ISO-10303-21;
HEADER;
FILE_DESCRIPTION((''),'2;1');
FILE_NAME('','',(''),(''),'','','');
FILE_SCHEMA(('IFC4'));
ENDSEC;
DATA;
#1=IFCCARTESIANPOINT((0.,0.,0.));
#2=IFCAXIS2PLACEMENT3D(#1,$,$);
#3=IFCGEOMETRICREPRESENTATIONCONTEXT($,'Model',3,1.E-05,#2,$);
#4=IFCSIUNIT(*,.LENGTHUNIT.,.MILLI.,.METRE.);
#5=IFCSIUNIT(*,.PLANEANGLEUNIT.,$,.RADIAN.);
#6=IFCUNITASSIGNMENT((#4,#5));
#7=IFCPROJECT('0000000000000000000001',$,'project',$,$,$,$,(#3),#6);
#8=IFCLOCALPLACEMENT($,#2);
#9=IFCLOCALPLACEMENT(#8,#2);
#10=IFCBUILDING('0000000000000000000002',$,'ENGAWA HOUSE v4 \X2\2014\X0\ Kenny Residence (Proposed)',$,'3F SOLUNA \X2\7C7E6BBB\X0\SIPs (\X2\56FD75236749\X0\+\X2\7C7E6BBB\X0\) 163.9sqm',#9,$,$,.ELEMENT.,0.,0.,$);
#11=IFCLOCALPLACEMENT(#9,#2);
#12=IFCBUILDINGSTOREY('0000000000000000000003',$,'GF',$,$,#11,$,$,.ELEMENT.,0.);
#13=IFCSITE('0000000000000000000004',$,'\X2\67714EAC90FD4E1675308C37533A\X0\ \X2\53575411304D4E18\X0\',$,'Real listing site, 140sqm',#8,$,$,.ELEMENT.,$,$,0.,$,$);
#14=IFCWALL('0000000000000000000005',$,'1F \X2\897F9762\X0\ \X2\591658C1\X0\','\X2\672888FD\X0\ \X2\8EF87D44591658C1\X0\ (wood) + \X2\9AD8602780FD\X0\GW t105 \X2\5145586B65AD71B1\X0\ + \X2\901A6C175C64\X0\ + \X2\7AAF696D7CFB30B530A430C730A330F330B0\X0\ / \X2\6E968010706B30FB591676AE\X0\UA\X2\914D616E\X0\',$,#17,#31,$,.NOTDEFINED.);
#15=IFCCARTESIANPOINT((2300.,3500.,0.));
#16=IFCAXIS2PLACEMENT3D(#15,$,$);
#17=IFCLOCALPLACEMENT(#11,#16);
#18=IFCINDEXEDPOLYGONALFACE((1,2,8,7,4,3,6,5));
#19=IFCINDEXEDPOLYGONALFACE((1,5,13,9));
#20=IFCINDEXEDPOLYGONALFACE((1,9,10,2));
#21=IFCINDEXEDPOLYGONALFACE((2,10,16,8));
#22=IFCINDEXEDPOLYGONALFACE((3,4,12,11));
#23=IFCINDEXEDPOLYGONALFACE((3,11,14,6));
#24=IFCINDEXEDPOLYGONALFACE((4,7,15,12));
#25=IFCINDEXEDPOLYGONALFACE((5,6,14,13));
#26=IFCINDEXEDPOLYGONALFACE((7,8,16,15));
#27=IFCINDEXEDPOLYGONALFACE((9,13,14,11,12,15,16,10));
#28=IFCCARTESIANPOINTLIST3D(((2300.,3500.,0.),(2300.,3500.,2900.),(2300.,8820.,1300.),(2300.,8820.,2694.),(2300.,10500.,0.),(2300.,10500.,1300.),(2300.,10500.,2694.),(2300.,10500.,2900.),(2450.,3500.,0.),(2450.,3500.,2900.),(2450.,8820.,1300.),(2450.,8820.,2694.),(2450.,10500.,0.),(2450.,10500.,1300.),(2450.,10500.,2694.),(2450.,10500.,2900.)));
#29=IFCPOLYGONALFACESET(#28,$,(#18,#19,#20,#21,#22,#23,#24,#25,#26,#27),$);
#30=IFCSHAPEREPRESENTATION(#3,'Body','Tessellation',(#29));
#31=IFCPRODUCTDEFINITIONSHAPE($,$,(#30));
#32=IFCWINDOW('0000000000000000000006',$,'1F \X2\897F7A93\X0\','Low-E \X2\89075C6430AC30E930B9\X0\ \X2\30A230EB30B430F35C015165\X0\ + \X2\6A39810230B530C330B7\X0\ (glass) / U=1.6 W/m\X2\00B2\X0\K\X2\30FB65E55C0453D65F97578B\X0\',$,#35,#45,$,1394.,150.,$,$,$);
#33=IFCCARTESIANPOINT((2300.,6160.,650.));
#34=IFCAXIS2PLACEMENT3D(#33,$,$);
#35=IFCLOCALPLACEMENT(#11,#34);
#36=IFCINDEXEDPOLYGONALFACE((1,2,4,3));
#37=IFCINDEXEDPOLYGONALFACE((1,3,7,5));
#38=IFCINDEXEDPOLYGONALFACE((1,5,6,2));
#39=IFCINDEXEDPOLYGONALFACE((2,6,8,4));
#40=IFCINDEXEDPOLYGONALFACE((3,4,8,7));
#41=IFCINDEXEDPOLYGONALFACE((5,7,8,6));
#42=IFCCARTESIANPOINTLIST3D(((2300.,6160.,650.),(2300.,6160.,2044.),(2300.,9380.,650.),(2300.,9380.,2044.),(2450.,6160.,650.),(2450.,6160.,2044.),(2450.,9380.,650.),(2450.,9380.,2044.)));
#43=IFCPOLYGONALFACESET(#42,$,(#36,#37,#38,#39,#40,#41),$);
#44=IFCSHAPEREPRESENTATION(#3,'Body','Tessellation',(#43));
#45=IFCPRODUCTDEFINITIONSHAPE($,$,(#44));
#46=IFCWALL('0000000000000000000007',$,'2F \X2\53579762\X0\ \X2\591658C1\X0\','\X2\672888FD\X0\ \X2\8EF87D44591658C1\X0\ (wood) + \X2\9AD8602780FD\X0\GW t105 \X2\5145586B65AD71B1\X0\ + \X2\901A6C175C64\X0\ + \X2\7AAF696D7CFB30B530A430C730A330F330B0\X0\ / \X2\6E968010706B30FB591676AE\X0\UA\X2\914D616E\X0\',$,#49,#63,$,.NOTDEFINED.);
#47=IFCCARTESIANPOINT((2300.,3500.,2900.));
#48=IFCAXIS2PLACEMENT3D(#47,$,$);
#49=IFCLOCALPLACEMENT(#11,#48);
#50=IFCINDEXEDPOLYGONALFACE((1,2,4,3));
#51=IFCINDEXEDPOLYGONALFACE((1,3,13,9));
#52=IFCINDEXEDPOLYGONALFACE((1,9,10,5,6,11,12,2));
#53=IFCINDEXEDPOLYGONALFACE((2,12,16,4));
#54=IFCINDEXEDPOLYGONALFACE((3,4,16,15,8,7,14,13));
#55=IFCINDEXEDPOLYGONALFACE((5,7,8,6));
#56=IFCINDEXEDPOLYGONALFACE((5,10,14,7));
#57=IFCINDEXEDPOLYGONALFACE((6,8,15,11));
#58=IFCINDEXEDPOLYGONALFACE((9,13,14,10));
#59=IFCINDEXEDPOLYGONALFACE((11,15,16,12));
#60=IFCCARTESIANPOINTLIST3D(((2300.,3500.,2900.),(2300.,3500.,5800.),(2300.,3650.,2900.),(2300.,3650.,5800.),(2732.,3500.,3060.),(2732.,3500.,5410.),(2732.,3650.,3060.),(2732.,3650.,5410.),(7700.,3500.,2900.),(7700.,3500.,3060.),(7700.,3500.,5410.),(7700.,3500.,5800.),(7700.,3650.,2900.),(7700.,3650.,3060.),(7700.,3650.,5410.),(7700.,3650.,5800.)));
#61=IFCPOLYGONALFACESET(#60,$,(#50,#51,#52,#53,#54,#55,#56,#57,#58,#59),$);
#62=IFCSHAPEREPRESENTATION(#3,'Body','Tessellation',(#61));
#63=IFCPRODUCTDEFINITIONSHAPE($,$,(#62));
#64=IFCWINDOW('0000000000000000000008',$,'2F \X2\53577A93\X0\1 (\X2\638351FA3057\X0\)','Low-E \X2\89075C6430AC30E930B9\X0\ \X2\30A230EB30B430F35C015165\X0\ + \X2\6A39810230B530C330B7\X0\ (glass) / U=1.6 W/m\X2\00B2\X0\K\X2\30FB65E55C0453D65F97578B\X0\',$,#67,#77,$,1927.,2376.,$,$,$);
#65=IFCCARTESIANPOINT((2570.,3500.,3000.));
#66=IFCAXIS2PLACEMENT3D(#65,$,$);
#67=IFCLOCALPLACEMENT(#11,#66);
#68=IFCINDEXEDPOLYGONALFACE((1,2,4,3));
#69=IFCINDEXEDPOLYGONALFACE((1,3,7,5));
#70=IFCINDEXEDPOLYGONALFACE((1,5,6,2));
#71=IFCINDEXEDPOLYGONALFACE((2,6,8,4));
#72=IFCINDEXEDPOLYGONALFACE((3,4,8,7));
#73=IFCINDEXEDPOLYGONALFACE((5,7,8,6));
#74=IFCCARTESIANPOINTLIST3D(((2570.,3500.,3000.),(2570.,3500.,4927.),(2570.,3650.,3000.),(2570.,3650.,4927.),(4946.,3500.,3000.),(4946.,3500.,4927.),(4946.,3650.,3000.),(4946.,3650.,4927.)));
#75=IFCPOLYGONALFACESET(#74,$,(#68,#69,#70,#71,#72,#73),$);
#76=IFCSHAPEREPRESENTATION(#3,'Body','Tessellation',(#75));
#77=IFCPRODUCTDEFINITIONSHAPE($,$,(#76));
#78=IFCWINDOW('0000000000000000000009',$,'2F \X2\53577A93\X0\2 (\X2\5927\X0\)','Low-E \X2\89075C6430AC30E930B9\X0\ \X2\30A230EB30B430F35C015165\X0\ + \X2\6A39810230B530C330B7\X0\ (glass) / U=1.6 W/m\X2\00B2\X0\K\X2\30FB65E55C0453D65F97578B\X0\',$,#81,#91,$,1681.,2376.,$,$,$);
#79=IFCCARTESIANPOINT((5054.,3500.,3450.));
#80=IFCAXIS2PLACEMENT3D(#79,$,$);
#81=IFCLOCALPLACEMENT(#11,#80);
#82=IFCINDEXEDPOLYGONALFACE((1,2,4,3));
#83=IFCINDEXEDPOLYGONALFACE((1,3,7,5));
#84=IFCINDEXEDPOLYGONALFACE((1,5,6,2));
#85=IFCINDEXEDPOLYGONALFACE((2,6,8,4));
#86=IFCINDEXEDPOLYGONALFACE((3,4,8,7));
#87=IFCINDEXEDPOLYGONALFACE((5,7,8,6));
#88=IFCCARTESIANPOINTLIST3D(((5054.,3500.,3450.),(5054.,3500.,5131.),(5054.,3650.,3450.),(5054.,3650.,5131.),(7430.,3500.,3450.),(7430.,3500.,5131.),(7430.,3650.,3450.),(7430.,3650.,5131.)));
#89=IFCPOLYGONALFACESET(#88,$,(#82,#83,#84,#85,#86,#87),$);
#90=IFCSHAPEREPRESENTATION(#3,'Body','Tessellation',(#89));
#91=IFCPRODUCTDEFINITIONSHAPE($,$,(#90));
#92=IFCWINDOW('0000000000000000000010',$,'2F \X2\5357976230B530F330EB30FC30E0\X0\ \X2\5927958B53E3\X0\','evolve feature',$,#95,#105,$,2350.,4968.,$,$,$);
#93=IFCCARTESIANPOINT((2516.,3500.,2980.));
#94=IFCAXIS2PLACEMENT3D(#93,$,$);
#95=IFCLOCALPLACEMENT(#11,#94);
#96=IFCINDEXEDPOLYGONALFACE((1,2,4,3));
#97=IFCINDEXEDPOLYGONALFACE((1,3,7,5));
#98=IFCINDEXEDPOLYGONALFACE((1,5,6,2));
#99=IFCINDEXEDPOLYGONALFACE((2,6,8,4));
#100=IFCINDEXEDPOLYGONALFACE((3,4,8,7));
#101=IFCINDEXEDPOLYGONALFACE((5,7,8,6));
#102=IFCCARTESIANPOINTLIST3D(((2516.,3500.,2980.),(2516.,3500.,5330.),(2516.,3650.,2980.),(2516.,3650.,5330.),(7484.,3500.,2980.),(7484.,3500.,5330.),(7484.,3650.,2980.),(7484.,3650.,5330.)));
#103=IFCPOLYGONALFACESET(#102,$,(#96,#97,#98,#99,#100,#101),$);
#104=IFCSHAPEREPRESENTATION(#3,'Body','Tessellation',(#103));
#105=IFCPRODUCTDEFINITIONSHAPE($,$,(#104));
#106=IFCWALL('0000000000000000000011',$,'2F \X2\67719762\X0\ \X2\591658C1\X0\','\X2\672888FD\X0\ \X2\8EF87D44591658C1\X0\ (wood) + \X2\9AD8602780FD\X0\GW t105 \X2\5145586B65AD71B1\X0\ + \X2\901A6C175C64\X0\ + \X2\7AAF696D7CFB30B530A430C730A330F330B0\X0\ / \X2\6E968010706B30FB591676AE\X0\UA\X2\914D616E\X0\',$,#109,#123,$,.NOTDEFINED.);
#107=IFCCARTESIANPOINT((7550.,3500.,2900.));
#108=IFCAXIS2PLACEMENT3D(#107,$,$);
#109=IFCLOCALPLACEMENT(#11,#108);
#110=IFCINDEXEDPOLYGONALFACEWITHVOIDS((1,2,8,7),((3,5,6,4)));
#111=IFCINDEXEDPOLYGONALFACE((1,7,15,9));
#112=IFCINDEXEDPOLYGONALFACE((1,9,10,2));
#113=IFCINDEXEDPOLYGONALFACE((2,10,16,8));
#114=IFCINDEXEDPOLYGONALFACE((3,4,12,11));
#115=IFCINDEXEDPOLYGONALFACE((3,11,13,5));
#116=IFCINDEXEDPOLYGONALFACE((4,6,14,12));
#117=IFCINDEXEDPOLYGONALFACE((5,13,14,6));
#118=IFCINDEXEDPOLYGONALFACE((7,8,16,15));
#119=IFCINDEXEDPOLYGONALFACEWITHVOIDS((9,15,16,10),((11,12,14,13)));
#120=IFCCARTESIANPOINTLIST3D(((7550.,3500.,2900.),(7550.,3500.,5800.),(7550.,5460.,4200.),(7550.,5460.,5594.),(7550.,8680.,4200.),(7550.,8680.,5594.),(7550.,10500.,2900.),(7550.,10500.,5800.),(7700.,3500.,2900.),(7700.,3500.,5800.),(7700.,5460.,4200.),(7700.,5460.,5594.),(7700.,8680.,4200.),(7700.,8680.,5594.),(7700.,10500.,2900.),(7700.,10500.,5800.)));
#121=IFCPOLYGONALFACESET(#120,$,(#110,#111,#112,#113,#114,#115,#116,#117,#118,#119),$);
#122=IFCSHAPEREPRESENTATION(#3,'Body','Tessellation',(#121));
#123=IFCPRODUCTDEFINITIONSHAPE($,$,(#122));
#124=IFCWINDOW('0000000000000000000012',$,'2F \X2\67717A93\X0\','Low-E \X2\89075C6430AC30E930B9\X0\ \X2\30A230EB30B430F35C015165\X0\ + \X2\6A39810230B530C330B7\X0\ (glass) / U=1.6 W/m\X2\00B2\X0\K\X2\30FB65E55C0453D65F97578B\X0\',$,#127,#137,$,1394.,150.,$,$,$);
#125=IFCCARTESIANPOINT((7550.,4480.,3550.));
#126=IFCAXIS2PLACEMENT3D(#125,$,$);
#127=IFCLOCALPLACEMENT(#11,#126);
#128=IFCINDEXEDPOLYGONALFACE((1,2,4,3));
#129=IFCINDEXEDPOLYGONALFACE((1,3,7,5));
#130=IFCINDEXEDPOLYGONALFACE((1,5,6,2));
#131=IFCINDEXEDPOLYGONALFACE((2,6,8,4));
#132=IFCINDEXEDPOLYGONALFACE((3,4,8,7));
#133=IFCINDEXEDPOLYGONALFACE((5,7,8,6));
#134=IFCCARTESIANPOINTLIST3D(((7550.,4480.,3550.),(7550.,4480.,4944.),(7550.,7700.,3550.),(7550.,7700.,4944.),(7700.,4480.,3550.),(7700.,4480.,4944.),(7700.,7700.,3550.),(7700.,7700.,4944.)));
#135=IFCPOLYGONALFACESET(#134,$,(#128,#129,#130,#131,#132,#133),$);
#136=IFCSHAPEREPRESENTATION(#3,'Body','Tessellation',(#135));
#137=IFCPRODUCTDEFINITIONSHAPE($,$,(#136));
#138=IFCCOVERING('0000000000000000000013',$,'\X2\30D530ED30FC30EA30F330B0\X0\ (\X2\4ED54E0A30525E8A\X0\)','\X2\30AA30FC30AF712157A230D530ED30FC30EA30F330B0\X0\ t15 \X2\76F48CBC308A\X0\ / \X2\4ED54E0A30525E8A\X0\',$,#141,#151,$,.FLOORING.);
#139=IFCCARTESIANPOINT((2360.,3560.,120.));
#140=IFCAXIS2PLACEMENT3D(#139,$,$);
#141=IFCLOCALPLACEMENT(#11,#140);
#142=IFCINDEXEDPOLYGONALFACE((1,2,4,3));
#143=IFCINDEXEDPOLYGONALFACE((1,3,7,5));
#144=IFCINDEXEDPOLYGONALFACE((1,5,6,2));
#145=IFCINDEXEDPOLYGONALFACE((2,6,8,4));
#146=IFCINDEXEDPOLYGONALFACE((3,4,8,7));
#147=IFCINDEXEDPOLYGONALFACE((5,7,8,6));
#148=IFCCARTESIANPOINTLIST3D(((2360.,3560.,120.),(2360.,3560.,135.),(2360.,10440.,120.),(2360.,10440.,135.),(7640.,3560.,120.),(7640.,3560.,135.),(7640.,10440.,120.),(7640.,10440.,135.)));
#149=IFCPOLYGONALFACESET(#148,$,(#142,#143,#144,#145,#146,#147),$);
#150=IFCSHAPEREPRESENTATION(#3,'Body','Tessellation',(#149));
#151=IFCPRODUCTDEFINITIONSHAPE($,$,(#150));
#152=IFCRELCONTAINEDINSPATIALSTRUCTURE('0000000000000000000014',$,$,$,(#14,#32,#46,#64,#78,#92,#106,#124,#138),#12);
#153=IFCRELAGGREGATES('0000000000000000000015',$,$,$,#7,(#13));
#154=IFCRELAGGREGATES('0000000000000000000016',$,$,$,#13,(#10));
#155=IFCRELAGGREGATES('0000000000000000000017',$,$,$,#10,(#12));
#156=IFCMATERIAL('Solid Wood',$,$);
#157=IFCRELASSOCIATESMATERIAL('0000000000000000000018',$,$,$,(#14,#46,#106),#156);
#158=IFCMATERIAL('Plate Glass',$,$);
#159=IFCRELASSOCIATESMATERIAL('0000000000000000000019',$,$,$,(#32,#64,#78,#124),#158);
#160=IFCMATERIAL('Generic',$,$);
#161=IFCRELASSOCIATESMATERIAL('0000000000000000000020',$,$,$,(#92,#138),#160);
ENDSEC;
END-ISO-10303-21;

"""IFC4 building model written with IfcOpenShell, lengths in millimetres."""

from ifc_helpers import new_model, si_unit, frame, frame_2d, origin, place, context, project, spatial, rectangle, extrude, material, element, fill, save


model = new_model("IFC4")

# Units and contexts
model_context = context("Model", 3, precision=1e-05, world=origin())
ifc_project = project(units=[si_unit("LENGTHUNIT", "METRE", prefix="MILLI"), si_unit("PLANEANGLEUNIT", "RADIAN")], contexts=[model_context])

# Site, building, storey
site_placement = place(None, origin())
site = spatial("IfcSite", under=ifc_project, at=site_placement, Name="東京都世田谷区 南向き丘", ObjectType="Real listing site, 140sqm", CompositionType="ELEMENT", RefElevation=0.0)
building_placement = place(site_placement, origin())
building = spatial("IfcBuilding", under=site, at=building_placement, Name="ENGAWA HOUSE v4 — Kenny Residence (Proposed)", ObjectType="3F SOLUNA 籾殻SIPs (国産杉+籾殻) 163.9sqm", CompositionType="ELEMENT", ElevationOfRefHeight=0.0, ElevationOfTerrain=0.0)
storey_placement = place(building_placement, origin())
storey = spatial("IfcBuildingStorey", under=building, at=storey_placement, Name="GF", CompositionType="ELEMENT", Elevation=0.0)

# Shared definitions
ifc_material_1 = material(Name="Solid Wood")
ifc_material_2 = material(Name="Generic")

# Shared definitions
ifc_material_3 = material(Name="Plate Glass")

# Wall, opening, window
wall_1_placement = place(storey_placement, frame((2300.0, 3500.0, 0.0)))
wall_1 = element("IfcWall", 1, at=wall_1_placement, inside=storey, material=ifc_material_1, Name="1F 西面 外壁", Description="木製 軸組外壁 (wood) + 高性能GW t105 充填断熱 + 通気層 + 窯業系サイディング / 準耐火・外皮UA配慮", PredefinedType="NOTDEFINED", context=model_context, shape_type="SweptSolid", body=[
    extrude(rectangle(XDim=150.0, YDim=7000.0, at=frame_2d((75.0, 3500.0))), frame((2300.0, 3500.0, 0.0)), (0.0, 0.0, 1.0), 2900.0),
])
opening_1_placement = place(storey_placement, frame((2300.0, 6160.0, 650.0)))
opening_1 = element("IfcOpeningElement", 2, at=opening_1_placement, cuts=wall_1, PredefinedType="NOTDEFINED", context=model_context, shape_type="SweptSolid", body=[
    extrude(rectangle(XDim=150.0, YDim=3220.0, at=frame_2d((75.0, 1610.0))), frame((2300.0, 6160.0, 650.0)), (0.0, 0.0, 1.0), 1394.0),
])
window_1_placement = place(storey_placement, frame((2300.0, 6160.0, 650.0)))
window_1 = element("IfcWindow", 3, at=window_1_placement, inside=storey, material=ifc_material_3, Name="1F 西窓", Description="Low-E 複層ガラス アルゴン封入 + 樹脂サッシ (glass) / U=1.6 W/m²K・日射取得型", OverallHeight=1394.0, OverallWidth=150.0, context=model_context, shape_type="SweptSolid", body=[
    extrude(rectangle(XDim=150.0, YDim=3220.0, at=frame_2d((75.0, 1610.0))), frame((2300.0, 6160.0, 650.0)), (0.0, 0.0, 1.0), 1394.0),
])
fill(opening_1, window_1)

# Wall, openings, windows
wall_2_placement = place(storey_placement, frame((2300.0, 3500.0, 2900.0)))
wall_2 = element("IfcWall", 4, at=wall_2_placement, inside=storey, material=ifc_material_1, Name="2F 南面 外壁", Description="木製 軸組外壁 (wood) + 高性能GW t105 充填断熱 + 通気層 + 窯業系サイディング / 準耐火・外皮UA配慮", PredefinedType="NOTDEFINED", context=model_context, shape_type="SweptSolid", body=[
    extrude(rectangle(XDim=5400.0, YDim=150.0, at=frame_2d((2700.0, 75.0))), frame((2300.0, 3500.0, 2900.0)), (0.0, 0.0, 1.0), 2900.0),
])
opening_2_placement = place(storey_placement, frame((2570.0, 3500.0, 3000.0)))
opening_2 = element("IfcOpeningElement", 5, at=opening_2_placement, cuts=wall_2, PredefinedType="NOTDEFINED", context=model_context, shape_type="SweptSolid", body=[
    extrude(rectangle(XDim=2376.0, YDim=150.0, at=frame_2d((1188.0, 75.0))), frame((2570.0, 3500.0, 3000.0)), (0.0, 0.0, 1.0), 1927.0),
])
opening_3_placement = place(storey_placement, frame((5054.0, 3500.0, 3450.0)))
opening_3 = element("IfcOpeningElement", 6, at=opening_3_placement, cuts=wall_2, PredefinedType="NOTDEFINED", context=model_context, shape_type="SweptSolid", body=[
    extrude(rectangle(XDim=2376.0, YDim=150.0, at=frame_2d((1188.0, 75.0))), frame((5054.0, 3500.0, 3450.0)), (0.0, 0.0, 1.0), 1681.0),
])
opening_4_placement = place(storey_placement, frame((2516.0, 3500.0, 2980.0)))
opening_4 = element("IfcOpeningElement", 7, at=opening_4_placement, cuts=wall_2, PredefinedType="NOTDEFINED", context=model_context, shape_type="SweptSolid", body=[
    extrude(rectangle(XDim=4968.0, YDim=150.0, at=frame_2d((2484.0, 75.0))), frame((2516.0, 3500.0, 2980.0)), (0.0, 0.0, 1.0), 2350.0),
])
window_2_placement = place(storey_placement, frame((2570.0, 3500.0, 3000.0)))
window_2 = element("IfcWindow", 8, at=window_2_placement, inside=storey, material=ifc_material_3, Name="2F 南窓1 (掃出し)", Description="Low-E 複層ガラス アルゴン封入 + 樹脂サッシ (glass) / U=1.6 W/m²K・日射取得型", OverallHeight=1927.0, OverallWidth=2376.0, context=model_context, shape_type="SweptSolid", body=[
    extrude(rectangle(XDim=2376.0, YDim=150.0, at=frame_2d((1188.0, 75.0))), frame((2570.0, 3500.0, 3000.0)), (0.0, 0.0, 1.0), 1927.0),
])
fill(opening_2, window_2)
window_3_placement = place(storey_placement, frame((5054.0, 3500.0, 3450.0)))
window_3 = element("IfcWindow", 9, at=window_3_placement, inside=storey, material=ifc_material_3, Name="2F 南窓2 (大)", Description="Low-E 複層ガラス アルゴン封入 + 樹脂サッシ (glass) / U=1.6 W/m²K・日射取得型", OverallHeight=1681.0, OverallWidth=2376.0, context=model_context, shape_type="SweptSolid", body=[
    extrude(rectangle(XDim=2376.0, YDim=150.0, at=frame_2d((1188.0, 75.0))), frame((5054.0, 3500.0, 3450.0)), (0.0, 0.0, 1.0), 1681.0),
])
fill(opening_3, window_3)
window_4_placement = place(storey_placement, frame((2516.0, 3500.0, 2980.0)))
window_4 = element("IfcWindow", 10, at=window_4_placement, inside=storey, material=ifc_material_2, Name="2F 南面サンルーム 大開口", Description="evolve feature", OverallHeight=2350.0, OverallWidth=4968.0, context=model_context, shape_type="SweptSolid", body=[
    extrude(rectangle(XDim=4968.0, YDim=150.0, at=frame_2d((2484.0, 75.0))), frame((2516.0, 3500.0, 2980.0)), (0.0, 0.0, 1.0), 2350.0),
])
fill(opening_4, window_4)

# Wall, opening, window
wall_3_placement = place(storey_placement, frame((7550.0, 3500.0, 2900.0)))
wall_3 = element("IfcWall", 11, at=wall_3_placement, inside=storey, material=ifc_material_1, Name="2F 東面 外壁", Description="木製 軸組外壁 (wood) + 高性能GW t105 充填断熱 + 通気層 + 窯業系サイディング / 準耐火・外皮UA配慮", PredefinedType="NOTDEFINED", context=model_context, shape_type="SweptSolid", body=[
    extrude(rectangle(XDim=150.0, YDim=7000.0, at=frame_2d((75.0, 3500.0))), frame((7550.0, 3500.0, 2900.0)), (0.0, 0.0, 1.0), 2900.0),
])
opening_5_placement = place(storey_placement, frame((7550.0, 4480.0, 3550.0)))
opening_5 = element("IfcOpeningElement", 12, at=opening_5_placement, cuts=wall_3, PredefinedType="NOTDEFINED", context=model_context, shape_type="SweptSolid", body=[
    extrude(rectangle(XDim=150.0, YDim=3220.0, at=frame_2d((75.0, 1610.0))), frame((7550.0, 4480.0, 3550.0)), (0.0, 0.0, 1.0), 1394.0),
])
window_5_placement = place(storey_placement, frame((7550.0, 4480.0, 3550.0)))
window_5 = element("IfcWindow", 13, at=window_5_placement, inside=storey, material=ifc_material_3, Name="2F 東窓", Description="Low-E 複層ガラス アルゴン封入 + 樹脂サッシ (glass) / U=1.6 W/m²K・日射取得型", OverallHeight=1394.0, OverallWidth=150.0, context=model_context, shape_type="SweptSolid", body=[
    extrude(rectangle(XDim=150.0, YDim=3220.0, at=frame_2d((75.0, 1610.0))), frame((7550.0, 4480.0, 3550.0)), (0.0, 0.0, 1.0), 1394.0),
])
fill(opening_5, window_5)

# Covering
covering_placement = place(storey_placement, frame((2360.0, 3560.0, 120.0)))
element("IfcCovering", 14, at=covering_placement, inside=storey, material=ifc_material_2, Name="フローリング (仕上げ床)", Description="オーク無垢フローリング t15 直貼り / 仕上げ床", PredefinedType="FLOORING", context=model_context, shape_type="SweptSolid", body=[
    extrude(rectangle(XDim=5280.0, YDim=6880.0, at=frame_2d((2640.0, 3440.0))), frame((2360.0, 3560.0, 120.0)), (0.0, 0.0, 1.0), 15.0),
])

save(model, "model.ifc")
